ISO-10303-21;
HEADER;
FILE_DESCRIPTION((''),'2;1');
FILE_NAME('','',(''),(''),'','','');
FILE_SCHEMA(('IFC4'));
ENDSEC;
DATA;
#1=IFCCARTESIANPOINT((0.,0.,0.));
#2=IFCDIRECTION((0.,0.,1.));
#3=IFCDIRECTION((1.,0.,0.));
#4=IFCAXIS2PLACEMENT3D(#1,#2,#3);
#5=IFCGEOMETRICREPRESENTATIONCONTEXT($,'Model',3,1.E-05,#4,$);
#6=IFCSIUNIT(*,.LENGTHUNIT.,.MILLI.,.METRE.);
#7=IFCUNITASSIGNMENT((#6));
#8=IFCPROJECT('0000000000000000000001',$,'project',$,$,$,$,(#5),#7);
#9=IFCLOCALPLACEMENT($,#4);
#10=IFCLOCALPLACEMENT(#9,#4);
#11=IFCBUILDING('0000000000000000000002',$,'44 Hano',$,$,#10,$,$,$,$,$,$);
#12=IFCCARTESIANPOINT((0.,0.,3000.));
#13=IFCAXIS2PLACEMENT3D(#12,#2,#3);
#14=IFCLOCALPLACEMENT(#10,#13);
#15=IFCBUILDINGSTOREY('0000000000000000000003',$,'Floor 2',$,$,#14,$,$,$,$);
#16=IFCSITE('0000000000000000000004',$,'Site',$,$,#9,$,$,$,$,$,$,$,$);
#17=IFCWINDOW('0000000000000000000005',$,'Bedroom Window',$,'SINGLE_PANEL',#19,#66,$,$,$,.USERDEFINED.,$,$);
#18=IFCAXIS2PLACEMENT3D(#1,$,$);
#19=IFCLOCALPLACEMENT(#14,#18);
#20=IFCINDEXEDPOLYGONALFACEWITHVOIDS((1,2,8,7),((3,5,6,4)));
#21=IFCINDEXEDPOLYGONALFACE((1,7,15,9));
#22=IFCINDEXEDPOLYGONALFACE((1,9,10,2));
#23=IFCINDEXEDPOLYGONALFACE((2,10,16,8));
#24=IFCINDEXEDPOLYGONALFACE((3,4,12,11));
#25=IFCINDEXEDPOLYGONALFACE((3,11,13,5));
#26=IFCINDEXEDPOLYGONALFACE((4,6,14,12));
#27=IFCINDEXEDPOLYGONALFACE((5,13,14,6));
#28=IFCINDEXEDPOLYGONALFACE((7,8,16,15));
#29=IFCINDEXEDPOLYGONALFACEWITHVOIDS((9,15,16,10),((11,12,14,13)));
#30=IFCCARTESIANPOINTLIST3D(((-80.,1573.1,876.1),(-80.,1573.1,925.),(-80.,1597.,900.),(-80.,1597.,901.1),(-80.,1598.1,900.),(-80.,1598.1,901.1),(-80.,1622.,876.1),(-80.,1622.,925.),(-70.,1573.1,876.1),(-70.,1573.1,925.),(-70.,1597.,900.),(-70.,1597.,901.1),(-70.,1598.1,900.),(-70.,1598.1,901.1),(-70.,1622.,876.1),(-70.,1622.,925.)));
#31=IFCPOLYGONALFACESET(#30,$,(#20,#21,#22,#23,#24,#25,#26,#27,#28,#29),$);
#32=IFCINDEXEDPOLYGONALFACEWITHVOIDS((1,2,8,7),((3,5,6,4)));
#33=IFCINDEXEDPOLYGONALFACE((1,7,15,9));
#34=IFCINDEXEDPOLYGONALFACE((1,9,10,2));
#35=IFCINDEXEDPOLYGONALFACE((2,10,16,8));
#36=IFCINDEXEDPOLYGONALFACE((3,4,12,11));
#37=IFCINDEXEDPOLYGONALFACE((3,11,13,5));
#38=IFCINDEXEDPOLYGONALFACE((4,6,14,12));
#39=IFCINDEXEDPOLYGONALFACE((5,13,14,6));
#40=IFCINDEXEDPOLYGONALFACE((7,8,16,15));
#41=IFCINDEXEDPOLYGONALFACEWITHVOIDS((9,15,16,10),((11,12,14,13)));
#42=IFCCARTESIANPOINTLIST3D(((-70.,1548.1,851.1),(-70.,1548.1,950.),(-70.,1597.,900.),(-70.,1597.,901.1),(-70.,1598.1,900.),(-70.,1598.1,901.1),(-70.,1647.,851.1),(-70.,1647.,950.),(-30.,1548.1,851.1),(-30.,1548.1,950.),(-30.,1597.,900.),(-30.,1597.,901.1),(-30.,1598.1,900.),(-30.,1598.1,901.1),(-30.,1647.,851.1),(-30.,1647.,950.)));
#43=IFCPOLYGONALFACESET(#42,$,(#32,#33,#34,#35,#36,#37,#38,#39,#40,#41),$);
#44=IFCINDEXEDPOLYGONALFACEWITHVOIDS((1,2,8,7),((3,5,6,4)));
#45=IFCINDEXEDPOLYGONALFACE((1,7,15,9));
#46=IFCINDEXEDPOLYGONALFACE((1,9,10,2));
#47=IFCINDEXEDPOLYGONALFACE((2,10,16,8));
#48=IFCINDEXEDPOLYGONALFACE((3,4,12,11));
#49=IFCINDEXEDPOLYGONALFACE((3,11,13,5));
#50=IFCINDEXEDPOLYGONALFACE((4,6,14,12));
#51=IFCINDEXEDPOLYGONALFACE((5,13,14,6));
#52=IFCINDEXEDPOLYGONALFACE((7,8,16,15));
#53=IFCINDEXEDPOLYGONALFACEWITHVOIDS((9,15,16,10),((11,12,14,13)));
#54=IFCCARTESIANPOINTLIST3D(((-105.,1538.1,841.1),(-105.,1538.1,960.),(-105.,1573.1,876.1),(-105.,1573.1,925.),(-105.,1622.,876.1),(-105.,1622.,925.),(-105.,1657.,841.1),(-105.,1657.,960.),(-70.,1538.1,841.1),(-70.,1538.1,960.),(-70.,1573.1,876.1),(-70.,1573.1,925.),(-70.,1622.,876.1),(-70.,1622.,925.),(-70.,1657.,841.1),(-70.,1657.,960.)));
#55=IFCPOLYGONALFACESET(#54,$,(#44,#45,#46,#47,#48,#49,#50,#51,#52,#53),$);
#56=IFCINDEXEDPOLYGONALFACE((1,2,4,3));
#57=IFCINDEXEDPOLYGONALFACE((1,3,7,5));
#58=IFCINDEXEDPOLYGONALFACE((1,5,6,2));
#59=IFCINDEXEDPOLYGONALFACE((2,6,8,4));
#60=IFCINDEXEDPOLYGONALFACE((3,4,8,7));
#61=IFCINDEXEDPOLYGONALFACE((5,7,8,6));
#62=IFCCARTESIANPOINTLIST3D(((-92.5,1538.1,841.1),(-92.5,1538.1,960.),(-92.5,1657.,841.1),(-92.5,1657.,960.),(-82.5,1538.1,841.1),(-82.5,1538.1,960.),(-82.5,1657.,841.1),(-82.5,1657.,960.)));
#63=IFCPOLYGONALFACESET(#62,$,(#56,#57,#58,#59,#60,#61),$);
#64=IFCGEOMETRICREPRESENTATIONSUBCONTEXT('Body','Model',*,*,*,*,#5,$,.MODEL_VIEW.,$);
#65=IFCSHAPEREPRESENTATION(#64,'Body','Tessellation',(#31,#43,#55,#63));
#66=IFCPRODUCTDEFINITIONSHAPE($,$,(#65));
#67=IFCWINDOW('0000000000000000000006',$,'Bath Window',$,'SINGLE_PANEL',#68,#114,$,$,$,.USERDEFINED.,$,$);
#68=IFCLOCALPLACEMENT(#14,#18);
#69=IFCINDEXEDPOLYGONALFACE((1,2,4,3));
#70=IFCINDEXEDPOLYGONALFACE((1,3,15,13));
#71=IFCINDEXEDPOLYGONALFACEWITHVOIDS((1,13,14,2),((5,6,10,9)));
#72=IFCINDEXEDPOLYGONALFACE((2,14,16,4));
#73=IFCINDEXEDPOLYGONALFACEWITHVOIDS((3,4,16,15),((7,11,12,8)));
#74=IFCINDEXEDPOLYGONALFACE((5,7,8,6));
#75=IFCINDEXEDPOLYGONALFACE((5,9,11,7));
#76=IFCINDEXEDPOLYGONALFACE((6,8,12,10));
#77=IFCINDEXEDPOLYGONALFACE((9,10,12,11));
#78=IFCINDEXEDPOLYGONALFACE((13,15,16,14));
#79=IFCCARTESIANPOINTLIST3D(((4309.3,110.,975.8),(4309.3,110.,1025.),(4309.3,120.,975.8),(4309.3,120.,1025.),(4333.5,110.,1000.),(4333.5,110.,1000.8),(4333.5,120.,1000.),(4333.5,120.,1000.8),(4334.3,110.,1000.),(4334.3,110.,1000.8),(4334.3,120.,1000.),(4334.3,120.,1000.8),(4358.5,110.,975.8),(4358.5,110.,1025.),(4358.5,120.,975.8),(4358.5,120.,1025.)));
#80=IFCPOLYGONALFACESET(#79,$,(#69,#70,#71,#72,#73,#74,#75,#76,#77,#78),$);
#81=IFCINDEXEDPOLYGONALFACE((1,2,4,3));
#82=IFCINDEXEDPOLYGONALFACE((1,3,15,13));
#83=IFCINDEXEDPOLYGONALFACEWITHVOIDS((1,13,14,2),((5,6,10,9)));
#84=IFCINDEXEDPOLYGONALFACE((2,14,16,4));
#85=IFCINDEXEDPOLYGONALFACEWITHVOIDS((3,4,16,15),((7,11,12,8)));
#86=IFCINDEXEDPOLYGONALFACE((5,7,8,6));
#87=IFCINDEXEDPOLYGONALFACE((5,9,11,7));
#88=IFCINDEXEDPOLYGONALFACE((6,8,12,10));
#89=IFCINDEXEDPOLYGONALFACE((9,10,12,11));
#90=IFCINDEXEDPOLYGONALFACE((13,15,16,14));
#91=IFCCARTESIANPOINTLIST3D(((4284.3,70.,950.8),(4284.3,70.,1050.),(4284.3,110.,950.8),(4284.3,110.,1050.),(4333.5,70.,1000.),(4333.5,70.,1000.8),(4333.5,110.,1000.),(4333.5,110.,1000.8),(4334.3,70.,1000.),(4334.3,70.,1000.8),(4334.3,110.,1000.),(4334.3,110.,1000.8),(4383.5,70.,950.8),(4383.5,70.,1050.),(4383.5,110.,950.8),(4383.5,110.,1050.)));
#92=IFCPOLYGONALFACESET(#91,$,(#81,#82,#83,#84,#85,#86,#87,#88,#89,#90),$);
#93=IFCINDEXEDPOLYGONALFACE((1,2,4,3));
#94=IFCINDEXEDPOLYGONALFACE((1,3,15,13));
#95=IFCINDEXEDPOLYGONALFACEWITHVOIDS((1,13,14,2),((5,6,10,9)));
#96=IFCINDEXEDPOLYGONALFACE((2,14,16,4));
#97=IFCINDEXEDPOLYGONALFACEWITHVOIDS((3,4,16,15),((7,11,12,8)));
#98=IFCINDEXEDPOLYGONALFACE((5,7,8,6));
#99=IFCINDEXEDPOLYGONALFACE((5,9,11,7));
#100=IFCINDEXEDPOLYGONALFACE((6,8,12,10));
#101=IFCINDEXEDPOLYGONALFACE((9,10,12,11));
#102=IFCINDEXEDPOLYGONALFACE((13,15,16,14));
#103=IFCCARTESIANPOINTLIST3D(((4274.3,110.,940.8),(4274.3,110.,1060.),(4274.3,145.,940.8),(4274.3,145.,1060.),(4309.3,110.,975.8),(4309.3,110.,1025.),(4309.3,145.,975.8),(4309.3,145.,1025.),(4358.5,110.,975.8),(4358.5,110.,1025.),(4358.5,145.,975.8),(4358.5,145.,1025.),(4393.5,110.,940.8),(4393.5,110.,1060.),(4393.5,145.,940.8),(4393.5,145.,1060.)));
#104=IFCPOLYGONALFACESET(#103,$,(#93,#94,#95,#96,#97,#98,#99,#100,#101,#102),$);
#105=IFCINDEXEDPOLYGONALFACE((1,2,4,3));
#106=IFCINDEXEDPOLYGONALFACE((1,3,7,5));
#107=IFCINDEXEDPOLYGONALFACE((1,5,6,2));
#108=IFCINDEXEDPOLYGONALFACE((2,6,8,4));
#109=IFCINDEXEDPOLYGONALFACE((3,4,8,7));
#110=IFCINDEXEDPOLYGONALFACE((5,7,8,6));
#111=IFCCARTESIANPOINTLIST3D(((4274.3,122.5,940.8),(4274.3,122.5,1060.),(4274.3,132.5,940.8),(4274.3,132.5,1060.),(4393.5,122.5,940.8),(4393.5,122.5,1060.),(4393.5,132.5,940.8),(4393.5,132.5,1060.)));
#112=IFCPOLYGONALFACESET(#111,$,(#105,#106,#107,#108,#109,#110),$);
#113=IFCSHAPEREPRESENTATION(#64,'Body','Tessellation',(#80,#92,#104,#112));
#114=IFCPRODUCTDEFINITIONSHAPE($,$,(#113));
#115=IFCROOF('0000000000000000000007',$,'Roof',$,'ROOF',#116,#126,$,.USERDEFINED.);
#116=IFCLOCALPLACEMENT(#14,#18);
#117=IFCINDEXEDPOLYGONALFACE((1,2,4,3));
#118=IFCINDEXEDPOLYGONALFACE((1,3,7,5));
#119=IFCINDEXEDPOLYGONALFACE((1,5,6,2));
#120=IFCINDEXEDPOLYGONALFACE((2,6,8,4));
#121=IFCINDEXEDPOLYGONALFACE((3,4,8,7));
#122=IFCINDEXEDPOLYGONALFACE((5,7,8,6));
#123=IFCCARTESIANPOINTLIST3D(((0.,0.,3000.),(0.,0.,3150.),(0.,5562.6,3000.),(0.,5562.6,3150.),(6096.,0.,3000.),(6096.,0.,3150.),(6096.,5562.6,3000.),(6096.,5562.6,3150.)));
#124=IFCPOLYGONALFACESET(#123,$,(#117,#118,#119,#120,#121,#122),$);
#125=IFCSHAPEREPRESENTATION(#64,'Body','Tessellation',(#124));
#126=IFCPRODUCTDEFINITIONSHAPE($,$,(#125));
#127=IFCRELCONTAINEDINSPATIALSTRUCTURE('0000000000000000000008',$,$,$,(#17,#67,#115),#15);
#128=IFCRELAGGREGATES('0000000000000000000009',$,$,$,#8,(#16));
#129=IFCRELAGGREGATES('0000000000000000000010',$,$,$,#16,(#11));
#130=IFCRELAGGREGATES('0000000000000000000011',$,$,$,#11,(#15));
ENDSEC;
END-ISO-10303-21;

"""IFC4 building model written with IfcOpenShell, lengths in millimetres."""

from ifc_helpers import new_model, si_unit, frame, origin_with_axes, place, context, subcontext, project, spatial, line, indexed_curve, outline, extrude, element, save


model = new_model("IFC4")

# Units and contexts
model_context = context("Model", 3, precision=1e-05, world=origin_with_axes())
body_context = subcontext(model_context, "Body", "Model", "MODEL_VIEW")
ifc_project = project(units=[si_unit("LENGTHUNIT", "METRE", prefix="MILLI")], contexts=[model_context])

# Site, building, storey
site_placement = place(None, origin_with_axes())
site = spatial("IfcSite", under=ifc_project, at=site_placement, Name="Site")
building_placement = place(site_placement, origin_with_axes())
building = spatial("IfcBuilding", under=site, at=building_placement, Name="44 Hano")
storey_placement = place(building_placement, frame((0.0, 0.0, 3000.0), z_axis=(0.0, 0.0, 1.0), x_axis=(1.0, 0.0, 0.0)))
storey = spatial("IfcBuildingStorey", under=building, at=storey_placement, Name="Floor 2")

# Windows
window_1_placement = place(storey_placement, frame((20.0, 1597.0, 900.0), z_axis=(0.0, 0.0, 1.0), x_axis=(0.0, 1.0, 0.0)))
element("IfcWindow", 1, at=window_1_placement, inside=storey, Name="Bedroom Window", ObjectType="SINGLE_PANEL", PredefinedType="USERDEFINED", context=body_context, shape_type="SweptSolid", body=[
    extrude(outline(indexed_curve([(0.0, 0.0), (1.1, 0.0), (1.1, 1.1), (0.0, 1.1)], segments=[line(1, 2, 3, 4, 1)]), holes=[indexed_curve([(25.0, 25.0), (-23.9, 25.0), (-23.9, -23.9), (25.0, -23.9)], segments=[line(1, 2, 3, 4, 1)])]), frame((0.0, 90.0, 0.0), z_axis=(0.0, -1.0, 0.0), x_axis=(1.0, 0.0, 0.0)), (0.0, 0.0, -1.0), 10.0),
    extrude(outline(indexed_curve([(0.0, 0.0), (1.1, 0.0), (1.1, 1.1), (0.0, 1.1)], segments=[line(1, 2, 3, 4, 1)]), holes=[indexed_curve([(50.0, 50.0), (-48.9, 50.0), (-48.9, -48.9), (50.0, -48.9)], segments=[line(1, 2, 3, 4, 1)])]), frame((0.0, 50.0, 0.0), z_axis=(0.0, -1.0, 0.0), x_axis=(1.0, 0.0, 0.0)), (0.0, 0.0, -1.0), 40.0),
    extrude(outline(indexed_curve([(0.0, 0.0), (-48.9, 0.0), (-48.9, -48.9), (0.0, -48.9)], segments=[line(1, 2, 3, 4, 1)]), holes=[indexed_curve([(35.0, 35.0), (-83.9, 35.0), (-83.9, -83.9), (35.0, -83.9)], segments=[line(1, 2, 3, 4, 1)])]), frame((25.0, 90.0, 25.0), z_axis=(0.0, -1.0, 0.0), x_axis=(1.0, 0.0, 0.0)), (0.0, 0.0, -1.0), 35.0),
    extrude(outline(indexed_curve([(35.0, 35.0), (-83.9, 35.0), (-83.9, -83.9), (35.0, -83.9)], segments=[line(1, 2, 3, 4, 1)])), frame((25.0, 102.5, 25.0), z_axis=(0.0, -1.0, 0.0), x_axis=(1.0, 0.0, 0.0)), (0.0, 0.0, -1.0), 10.0),
])
window_2_placement = place(storey_placement, frame((4333.5, 20.0, 1000.0), z_axis=(0.0, 0.0, 1.0), x_axis=(1.0, 0.0, 0.0)))
element("IfcWindow", 2, at=window_2_placement, inside=storey, Name="Bath Window", ObjectType="SINGLE_PANEL", PredefinedType="USERDEFINED", context=body_context, shape_type="SweptSolid", body=[
    extrude(outline(indexed_curve([(0.0, 0.0), (0.8, 0.0), (0.8, 0.8), (0.0, 0.8)], segments=[line(1, 2, 3, 4, 1)]), holes=[indexed_curve([(25.0, 25.0), (-24.2, 25.0), (-24.2, -24.2), (25.0, -24.2)], segments=[line(1, 2, 3, 4, 1)])]), frame((0.0, 90.0, 0.0), z_axis=(0.0, -1.0, 0.0), x_axis=(1.0, 0.0, 0.0)), (0.0, 0.0, -1.0), 10.0),
    extrude(outline(indexed_curve([(0.0, 0.0), (0.8, 0.0), (0.8, 0.8), (0.0, 0.8)], segments=[line(1, 2, 3, 4, 1)]), holes=[indexed_curve([(50.0, 50.0), (-49.2, 50.0), (-49.2, -49.2), (50.0, -49.2)], segments=[line(1, 2, 3, 4, 1)])]), frame((0.0, 50.0, 0.0), z_axis=(0.0, -1.0, 0.0), x_axis=(1.0, 0.0, 0.0)), (0.0, 0.0, -1.0), 40.0),
    extrude(outline(indexed_curve([(0.0, 0.0), (-49.2, 0.0), (-49.2, -49.2), (0.0, -49.2)], segments=[line(1, 2, 3, 4, 1)]), holes=[indexed_curve([(35.0, 35.0), (-84.2, 35.0), (-84.2, -84.2), (35.0, -84.2)], segments=[line(1, 2, 3, 4, 1)])]), frame((25.0, 90.0, 25.0), z_axis=(0.0, -1.0, 0.0), x_axis=(1.0, 0.0, 0.0)), (0.0, 0.0, -1.0), 35.0),
    extrude(outline(indexed_curve([(35.0, 35.0), (-84.2, 35.0), (-84.2, -84.2), (35.0, -84.2)], segments=[line(1, 2, 3, 4, 1)])), frame((25.0, 102.5, 25.0), z_axis=(0.0, -1.0, 0.0), x_axis=(1.0, 0.0, 0.0)), (0.0, 0.0, -1.0), 10.0),
])

# Roof
roof_placement = place(storey_placement, frame((0.0, 0.0, 3000.0), z_axis=(0.0, 0.0, 1.0), x_axis=(1.0, 0.0, 0.0)))
element("IfcRoof", 3, at=roof_placement, inside=storey, Name="Roof", ObjectType="ROOF", PredefinedType="USERDEFINED", context=body_context, shape_type="SweptSolid", body=[
    extrude(outline(indexed_curve([(0.0, 0.0), (6096.0, 0.0), (6096.0, 5562.6), (0.0, 5562.6), (0.0, 0.0)])), None, (0.0, 0.0, 1.0), 150.0),
])

save(model, "model.ifc")
